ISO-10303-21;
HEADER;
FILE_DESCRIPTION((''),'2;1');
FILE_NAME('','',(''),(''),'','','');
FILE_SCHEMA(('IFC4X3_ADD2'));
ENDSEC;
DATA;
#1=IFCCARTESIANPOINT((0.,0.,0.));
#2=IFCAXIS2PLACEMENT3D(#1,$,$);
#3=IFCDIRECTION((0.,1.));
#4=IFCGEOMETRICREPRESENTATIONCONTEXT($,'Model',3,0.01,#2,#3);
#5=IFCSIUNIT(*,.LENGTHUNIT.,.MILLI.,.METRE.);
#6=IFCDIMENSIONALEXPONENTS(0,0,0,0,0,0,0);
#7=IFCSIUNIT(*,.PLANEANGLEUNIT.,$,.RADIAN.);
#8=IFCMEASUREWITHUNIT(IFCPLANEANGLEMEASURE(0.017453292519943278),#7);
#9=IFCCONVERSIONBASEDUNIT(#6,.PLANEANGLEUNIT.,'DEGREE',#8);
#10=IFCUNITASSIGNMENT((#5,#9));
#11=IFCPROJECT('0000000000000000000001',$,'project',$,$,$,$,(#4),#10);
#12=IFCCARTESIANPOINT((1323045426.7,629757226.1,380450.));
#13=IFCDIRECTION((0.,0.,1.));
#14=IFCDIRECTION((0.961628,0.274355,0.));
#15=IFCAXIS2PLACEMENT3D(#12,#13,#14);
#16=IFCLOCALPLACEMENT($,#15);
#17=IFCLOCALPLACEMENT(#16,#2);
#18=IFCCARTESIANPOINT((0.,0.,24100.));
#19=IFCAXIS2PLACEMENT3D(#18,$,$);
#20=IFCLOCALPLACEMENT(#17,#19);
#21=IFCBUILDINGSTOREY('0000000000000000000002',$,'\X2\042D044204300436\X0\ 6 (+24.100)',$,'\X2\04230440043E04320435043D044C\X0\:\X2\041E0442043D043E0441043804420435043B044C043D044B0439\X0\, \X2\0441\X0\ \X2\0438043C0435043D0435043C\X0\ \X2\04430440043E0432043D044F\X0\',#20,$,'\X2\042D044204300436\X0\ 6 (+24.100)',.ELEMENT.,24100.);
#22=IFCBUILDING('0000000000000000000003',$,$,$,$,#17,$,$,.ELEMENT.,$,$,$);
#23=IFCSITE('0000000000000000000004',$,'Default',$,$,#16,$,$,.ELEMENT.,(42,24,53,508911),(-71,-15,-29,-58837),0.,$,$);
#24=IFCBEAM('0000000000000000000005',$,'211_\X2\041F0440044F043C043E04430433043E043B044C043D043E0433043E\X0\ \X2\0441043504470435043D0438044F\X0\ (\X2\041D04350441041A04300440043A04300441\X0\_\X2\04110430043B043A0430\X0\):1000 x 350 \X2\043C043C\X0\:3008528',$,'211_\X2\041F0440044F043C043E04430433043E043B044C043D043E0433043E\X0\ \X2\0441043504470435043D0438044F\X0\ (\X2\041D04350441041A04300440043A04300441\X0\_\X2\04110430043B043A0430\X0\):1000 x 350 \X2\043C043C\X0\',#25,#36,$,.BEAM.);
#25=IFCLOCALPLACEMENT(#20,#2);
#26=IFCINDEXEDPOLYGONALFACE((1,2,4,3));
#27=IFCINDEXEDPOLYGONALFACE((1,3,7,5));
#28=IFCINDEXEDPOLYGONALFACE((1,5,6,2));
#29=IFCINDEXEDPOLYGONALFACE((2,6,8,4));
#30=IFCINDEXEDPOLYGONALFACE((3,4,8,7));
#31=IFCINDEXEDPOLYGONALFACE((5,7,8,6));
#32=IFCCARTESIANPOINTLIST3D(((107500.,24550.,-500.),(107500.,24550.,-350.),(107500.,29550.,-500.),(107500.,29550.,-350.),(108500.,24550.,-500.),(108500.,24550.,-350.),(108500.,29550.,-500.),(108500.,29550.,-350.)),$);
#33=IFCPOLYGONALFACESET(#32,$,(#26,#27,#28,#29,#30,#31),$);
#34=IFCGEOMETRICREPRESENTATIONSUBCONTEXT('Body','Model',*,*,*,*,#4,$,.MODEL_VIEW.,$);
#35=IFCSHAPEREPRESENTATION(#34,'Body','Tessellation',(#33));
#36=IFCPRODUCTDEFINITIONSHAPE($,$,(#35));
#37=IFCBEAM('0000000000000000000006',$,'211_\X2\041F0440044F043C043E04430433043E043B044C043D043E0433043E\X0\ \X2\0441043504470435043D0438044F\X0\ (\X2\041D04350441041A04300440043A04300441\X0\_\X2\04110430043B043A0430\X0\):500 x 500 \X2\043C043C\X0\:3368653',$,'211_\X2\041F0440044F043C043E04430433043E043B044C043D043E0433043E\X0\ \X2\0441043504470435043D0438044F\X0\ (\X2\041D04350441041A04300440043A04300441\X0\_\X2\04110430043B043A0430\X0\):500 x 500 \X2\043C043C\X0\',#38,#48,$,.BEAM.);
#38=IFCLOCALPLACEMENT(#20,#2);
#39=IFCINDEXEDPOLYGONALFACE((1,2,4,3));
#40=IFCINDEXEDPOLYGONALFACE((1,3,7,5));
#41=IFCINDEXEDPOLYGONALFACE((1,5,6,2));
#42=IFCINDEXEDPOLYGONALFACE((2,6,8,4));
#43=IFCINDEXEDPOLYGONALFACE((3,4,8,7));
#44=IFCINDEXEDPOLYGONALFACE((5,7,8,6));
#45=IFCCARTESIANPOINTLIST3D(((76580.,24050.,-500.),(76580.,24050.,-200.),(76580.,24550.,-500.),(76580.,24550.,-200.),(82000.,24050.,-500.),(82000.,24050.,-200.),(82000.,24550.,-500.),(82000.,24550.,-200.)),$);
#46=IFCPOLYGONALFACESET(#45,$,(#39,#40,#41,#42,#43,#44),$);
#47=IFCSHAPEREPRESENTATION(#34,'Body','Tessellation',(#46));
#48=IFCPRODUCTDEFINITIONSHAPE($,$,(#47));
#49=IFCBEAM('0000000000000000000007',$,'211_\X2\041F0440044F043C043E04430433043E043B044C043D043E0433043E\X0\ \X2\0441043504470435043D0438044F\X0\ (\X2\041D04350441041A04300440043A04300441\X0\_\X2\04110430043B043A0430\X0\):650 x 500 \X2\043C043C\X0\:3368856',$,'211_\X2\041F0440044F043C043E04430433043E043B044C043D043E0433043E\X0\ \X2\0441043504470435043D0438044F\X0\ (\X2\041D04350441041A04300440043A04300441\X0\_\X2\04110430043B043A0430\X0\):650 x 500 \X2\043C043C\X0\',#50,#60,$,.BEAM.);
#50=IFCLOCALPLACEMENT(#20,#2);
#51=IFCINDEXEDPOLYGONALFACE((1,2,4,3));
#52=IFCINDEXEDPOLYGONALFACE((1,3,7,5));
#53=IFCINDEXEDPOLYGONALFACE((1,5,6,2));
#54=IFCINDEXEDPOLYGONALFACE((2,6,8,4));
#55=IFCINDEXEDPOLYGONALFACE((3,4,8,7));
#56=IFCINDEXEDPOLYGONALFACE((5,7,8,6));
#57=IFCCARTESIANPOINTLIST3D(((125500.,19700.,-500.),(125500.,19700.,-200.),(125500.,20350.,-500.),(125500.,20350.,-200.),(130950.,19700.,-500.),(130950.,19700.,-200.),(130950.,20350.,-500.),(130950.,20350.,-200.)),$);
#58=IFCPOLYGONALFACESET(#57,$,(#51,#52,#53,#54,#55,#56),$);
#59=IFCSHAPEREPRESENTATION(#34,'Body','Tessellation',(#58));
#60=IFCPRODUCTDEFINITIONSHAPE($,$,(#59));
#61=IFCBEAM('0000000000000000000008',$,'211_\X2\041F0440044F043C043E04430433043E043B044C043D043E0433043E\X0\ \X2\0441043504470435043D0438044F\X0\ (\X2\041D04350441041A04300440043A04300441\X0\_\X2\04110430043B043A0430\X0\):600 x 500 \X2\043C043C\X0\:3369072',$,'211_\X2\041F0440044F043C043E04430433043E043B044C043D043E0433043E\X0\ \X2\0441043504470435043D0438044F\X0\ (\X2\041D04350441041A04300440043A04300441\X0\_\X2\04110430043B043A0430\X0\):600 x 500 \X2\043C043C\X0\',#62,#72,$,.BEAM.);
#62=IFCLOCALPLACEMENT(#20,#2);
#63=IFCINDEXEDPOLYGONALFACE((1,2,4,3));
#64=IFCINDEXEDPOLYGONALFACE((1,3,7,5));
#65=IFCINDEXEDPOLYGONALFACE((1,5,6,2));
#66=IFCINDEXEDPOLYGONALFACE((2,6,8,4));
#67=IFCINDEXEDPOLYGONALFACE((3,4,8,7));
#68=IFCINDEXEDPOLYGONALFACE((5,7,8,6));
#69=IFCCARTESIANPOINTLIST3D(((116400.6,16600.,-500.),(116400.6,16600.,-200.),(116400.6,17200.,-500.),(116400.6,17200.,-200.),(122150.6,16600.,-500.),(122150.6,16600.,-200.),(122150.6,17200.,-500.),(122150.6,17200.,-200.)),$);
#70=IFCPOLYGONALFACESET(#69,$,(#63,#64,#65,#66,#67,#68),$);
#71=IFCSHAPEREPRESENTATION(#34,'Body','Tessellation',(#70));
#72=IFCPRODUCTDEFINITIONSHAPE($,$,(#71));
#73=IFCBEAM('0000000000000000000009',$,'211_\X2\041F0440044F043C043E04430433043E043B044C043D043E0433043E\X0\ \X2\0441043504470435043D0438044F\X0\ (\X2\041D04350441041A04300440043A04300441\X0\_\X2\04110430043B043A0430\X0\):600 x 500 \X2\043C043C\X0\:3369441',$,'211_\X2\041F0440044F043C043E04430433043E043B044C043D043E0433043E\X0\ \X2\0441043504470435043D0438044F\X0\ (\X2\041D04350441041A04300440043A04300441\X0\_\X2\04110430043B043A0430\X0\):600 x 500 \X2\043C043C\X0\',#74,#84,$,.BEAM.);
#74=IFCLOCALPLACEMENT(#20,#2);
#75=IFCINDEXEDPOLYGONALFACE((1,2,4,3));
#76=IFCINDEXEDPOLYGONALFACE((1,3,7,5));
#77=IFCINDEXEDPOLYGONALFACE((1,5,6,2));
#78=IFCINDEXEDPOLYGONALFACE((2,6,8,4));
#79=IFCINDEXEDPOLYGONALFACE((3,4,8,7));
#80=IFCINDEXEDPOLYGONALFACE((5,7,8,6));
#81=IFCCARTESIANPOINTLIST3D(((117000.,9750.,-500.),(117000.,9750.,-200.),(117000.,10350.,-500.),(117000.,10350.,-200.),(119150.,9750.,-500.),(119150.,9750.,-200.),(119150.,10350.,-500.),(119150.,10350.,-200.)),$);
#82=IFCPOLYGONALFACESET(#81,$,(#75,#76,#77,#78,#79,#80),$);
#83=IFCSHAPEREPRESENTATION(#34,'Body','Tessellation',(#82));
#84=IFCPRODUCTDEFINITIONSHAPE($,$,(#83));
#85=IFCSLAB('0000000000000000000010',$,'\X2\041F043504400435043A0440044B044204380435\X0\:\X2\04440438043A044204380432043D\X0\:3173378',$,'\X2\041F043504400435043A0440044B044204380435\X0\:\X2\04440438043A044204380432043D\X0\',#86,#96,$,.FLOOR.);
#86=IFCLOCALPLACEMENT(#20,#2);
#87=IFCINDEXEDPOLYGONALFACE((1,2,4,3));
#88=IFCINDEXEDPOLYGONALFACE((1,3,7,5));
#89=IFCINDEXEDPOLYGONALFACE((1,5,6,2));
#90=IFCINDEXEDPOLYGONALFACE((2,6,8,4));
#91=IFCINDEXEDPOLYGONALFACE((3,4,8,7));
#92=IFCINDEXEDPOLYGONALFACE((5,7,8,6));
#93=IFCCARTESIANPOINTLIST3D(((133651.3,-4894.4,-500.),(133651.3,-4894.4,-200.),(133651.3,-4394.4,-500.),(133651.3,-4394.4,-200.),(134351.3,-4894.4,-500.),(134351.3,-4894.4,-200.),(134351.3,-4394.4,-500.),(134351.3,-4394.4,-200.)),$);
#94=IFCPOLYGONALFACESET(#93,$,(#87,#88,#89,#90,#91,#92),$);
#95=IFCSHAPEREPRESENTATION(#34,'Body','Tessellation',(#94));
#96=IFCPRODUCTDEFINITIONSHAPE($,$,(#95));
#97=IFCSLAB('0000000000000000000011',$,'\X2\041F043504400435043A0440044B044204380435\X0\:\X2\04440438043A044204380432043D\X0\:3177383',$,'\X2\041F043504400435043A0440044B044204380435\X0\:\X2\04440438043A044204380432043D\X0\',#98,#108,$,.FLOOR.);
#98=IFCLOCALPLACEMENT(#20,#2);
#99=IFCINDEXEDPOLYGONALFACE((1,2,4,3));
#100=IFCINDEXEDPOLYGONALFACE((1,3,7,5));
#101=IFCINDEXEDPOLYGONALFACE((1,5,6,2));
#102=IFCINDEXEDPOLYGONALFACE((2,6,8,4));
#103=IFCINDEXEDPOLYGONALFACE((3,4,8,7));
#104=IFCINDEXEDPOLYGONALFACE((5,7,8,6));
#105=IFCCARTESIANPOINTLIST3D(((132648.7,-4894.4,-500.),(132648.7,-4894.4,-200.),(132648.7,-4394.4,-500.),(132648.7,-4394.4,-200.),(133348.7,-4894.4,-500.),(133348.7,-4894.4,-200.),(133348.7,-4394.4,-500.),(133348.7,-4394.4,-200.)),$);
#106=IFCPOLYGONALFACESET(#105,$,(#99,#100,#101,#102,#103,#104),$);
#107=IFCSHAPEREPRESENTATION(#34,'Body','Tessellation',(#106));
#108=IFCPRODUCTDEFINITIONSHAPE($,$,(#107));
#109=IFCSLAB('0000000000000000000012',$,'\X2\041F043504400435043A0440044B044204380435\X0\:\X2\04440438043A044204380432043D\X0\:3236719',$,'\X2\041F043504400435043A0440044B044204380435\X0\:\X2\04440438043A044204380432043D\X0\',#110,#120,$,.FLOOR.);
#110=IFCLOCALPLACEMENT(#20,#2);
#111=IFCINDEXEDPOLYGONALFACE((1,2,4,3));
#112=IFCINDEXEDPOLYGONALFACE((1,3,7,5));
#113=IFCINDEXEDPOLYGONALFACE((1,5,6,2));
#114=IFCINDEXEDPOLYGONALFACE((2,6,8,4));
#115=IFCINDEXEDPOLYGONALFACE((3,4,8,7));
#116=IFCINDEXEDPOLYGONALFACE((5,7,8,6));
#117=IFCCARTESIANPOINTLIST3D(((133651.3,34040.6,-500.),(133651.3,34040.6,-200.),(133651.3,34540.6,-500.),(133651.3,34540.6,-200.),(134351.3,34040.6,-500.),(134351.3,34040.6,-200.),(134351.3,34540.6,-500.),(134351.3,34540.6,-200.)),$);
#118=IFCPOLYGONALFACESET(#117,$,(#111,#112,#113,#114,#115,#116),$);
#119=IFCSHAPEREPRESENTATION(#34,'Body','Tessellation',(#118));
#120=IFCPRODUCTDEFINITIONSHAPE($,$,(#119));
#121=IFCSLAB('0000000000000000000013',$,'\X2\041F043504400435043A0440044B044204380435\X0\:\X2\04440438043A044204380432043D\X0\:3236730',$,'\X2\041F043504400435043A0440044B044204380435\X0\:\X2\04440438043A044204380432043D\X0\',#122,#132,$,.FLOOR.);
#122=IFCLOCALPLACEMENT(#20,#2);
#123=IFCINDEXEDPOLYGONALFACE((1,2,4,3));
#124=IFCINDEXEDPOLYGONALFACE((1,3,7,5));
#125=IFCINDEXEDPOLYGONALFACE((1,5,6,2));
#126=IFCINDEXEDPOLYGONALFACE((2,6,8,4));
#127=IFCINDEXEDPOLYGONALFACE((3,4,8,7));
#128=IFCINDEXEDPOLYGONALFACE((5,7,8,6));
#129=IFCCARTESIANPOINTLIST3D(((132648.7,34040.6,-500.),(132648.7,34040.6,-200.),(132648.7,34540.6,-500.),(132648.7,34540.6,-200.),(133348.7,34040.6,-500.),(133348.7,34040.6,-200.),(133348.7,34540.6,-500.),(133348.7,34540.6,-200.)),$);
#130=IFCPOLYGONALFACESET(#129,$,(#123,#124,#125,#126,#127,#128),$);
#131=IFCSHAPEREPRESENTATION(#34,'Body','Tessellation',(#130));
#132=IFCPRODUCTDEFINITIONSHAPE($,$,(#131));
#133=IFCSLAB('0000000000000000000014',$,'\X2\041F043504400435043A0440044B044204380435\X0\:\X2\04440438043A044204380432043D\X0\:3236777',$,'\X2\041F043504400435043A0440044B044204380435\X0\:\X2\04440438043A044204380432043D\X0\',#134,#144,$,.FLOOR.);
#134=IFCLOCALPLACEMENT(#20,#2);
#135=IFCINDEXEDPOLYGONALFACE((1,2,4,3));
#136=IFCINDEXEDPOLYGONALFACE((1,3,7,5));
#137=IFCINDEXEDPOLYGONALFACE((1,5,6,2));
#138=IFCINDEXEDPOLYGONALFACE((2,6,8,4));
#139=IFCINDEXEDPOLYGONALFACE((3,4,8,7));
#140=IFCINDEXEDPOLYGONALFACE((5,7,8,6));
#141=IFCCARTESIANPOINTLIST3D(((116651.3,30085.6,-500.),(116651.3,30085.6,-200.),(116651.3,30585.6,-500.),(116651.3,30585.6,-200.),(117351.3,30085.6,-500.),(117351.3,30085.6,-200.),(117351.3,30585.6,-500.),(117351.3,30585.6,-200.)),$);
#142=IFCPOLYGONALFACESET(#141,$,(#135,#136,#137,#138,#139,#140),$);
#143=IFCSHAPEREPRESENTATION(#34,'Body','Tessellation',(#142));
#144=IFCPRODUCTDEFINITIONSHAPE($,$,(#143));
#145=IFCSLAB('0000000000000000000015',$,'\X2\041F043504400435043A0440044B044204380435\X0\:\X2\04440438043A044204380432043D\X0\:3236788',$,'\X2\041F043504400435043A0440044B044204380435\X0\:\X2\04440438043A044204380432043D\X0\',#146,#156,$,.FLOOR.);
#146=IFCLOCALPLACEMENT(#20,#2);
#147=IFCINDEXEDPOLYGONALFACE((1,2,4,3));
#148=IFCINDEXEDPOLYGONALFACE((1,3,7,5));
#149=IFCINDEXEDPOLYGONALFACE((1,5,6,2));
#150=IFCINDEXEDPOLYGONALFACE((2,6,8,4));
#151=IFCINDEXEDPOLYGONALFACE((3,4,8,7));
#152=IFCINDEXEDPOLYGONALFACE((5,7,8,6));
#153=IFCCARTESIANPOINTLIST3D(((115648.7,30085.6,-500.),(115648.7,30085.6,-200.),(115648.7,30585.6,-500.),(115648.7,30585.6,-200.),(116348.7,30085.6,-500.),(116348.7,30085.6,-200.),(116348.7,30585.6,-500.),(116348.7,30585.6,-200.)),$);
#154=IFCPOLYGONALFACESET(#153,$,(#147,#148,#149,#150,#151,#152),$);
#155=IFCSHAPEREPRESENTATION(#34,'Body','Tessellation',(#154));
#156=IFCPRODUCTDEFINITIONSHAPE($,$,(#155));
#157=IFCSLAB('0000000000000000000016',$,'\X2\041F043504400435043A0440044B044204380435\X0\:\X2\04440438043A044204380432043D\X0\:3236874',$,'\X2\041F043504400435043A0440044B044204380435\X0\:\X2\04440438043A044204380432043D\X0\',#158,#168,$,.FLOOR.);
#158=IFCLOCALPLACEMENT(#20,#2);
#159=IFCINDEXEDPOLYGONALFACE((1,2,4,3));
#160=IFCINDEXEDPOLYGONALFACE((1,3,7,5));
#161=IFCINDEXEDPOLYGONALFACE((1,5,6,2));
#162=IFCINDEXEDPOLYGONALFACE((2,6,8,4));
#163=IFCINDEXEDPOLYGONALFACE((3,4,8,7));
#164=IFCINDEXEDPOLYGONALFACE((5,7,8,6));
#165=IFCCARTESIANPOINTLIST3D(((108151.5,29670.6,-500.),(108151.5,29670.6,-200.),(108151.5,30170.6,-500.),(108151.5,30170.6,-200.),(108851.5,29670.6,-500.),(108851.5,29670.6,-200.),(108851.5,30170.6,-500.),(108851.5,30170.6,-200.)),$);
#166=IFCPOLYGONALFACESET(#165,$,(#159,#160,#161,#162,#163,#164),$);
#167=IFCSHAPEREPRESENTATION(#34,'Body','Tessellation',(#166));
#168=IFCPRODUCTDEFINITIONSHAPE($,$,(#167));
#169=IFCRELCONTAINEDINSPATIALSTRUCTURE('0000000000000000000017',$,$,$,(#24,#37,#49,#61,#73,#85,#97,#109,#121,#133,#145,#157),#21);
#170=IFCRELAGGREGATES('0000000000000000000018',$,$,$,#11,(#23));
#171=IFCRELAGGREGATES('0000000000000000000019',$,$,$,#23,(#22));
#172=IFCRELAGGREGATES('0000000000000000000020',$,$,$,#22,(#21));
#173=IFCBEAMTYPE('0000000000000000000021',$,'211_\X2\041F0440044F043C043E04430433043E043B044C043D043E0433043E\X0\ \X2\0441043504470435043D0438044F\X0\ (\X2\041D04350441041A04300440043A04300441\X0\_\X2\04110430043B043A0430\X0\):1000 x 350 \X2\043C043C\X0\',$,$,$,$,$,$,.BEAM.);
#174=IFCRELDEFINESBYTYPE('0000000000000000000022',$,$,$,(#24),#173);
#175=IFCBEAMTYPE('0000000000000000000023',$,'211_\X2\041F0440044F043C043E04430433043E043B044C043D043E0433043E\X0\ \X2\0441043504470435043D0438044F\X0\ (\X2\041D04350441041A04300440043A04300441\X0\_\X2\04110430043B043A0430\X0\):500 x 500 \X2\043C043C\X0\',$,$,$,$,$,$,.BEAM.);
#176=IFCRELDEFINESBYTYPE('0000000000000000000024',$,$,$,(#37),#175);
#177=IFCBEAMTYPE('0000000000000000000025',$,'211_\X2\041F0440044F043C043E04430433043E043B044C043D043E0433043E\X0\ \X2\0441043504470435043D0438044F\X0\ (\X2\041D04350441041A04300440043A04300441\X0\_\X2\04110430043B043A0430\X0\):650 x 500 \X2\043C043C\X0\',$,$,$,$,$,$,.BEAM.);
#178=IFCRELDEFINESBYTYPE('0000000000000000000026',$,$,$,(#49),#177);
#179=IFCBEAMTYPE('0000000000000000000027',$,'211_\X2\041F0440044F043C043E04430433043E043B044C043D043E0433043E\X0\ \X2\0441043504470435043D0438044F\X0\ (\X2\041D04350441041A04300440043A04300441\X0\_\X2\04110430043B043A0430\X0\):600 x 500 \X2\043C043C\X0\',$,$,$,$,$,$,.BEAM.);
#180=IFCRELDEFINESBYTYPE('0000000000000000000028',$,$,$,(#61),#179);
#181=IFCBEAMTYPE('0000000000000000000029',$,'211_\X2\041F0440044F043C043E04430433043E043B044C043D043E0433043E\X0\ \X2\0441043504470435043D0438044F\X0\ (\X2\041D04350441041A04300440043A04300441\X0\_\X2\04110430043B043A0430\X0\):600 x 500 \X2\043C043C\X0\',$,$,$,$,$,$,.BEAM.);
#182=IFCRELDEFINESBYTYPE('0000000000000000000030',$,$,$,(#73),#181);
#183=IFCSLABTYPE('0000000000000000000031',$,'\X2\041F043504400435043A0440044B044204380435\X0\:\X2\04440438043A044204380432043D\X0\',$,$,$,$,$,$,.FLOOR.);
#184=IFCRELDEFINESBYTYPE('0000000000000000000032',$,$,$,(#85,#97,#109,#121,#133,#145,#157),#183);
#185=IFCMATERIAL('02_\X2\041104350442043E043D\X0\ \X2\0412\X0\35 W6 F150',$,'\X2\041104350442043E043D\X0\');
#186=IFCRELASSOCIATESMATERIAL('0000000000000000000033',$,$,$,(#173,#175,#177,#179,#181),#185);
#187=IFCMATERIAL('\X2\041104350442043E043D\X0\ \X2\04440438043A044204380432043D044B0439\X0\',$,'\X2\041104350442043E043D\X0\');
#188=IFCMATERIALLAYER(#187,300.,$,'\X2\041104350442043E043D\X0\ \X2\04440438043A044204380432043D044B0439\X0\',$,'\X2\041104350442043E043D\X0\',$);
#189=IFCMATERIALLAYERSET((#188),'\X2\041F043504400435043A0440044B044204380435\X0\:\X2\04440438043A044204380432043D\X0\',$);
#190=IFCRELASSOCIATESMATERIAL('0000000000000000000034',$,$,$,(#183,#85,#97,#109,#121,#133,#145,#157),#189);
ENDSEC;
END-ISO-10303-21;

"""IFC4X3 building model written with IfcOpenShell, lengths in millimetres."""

from ifc_helpers import new_model, entity, si_unit, converted_unit, direction, frame, frame_2d, origin, origin_2d_with_axis, place, context, subcontext, project, spatial, rectangle, extrude, source, transform, mapped, material, layer, layer_set, layer_usage, material_profile, profile_set, type_object, type_shapes, element, save


model = new_model("IFC4X3")

# Units and contexts
model_context = context("Model", 3, precision=0.01, world=origin(), true_north=direction((0.0, 1.0)))
body_context = subcontext(model_context, "Body", "Model", "MODEL_VIEW")
ifc_project = project(units=[si_unit("LENGTHUNIT", "METRE", prefix="MILLI"), converted_unit("PLANEANGLEUNIT", "DEGREE", entity("IfcPlaneAngleMeasure", 0.017453292519943278), si_unit("PLANEANGLEUNIT", "RADIAN"), dimensions=[0, 0, 0, 0, 0, 0, 0])], contexts=[model_context])

# Site, building, storey
site_placement = place(None, frame((1323045426.7, 629757226.1, 380450.0), z_axis=(0.0, 0.0, 1.0), x_axis=(0.961628, 0.274355, 0.0)))
site = spatial("IfcSite", under=ifc_project, at=site_placement, Name="Default", CompositionType="ELEMENT", RefLatitude=(42, 24, 53, 508911), RefLongitude=(-71, -15, -29, -58837), RefElevation=0.0)
building_placement = place(site_placement, origin())
building = spatial("IfcBuilding", under=site, at=building_placement, CompositionType="ELEMENT")
storey_placement = place(building_placement, frame((0.0, 0.0, 24100.0)))
storey = spatial("IfcBuildingStorey", under=building, at=storey_placement, Name="Этаж 6 (+24.100)", ObjectType="Уровень:Относительный, с именем уровня", LongName="Этаж 6 (+24.100)", CompositionType="ELEMENT", Elevation=24100.0)

# Beams
ifc_material_1 = material(Name="02_Бетон В35 W6 F150", Category="Бетон")
ifc_material_profile_1 = material_profile(ifc_material_1, rectangle(XDim=150.0, YDim=1000.0, at=frame_2d((0.0, 0.0), x_axis=(0.0, 1.0))), Name="1000 x 350 мм")
ifc_profile_set_1 = profile_set([ifc_material_profile_1], Name="1000 x 350 мм")
beam_type_1 = type_object("IfcBeamType", Name="211_Прямоугольного сечения (НесКаркас_Балка):1000 x 350 мм", PredefinedType="BEAM", material=ifc_profile_set_1)
shared_shape_1 = source(origin(), body_context, "Body", "SweptSolid", [
    extrude(rectangle(XDim=150.0, YDim=1000.0, at=frame_2d((0.0, 0.0), x_axis=(0.0, 1.0))), frame((108000.0, 29550.0, 23675.0), z_axis=(0.0, -1.0, 0.0), x_axis=(-1.0, 0.0, 0.0)), (0.0, 0.0, 1.0), 5000.0),
])
type_shapes(beam_type_1, [shared_shape_1])
beam_1_placement = place(storey_placement, frame((0.0, 0.0, -24100.0)))
element("IfcBeam", 1, at=beam_1_placement, inside=storey, type_object=beam_type_1, Name="211_Прямоугольного сечения (НесКаркас_Балка):1000 x 350 мм:3008528", ObjectType="211_Прямоугольного сечения (НесКаркас_Балка):1000 x 350 мм", PredefinedType="BEAM", context=body_context, shape_type="MappedRepresentation", body=[
    mapped(shared_shape_1, transform((0.0, 0.0, 0.0), scale=1.0)),
])
ifc_material_profile_2 = material_profile(ifc_material_1, rectangle(XDim=300.0, YDim=500.0, at=frame_2d((0.0, 0.0), x_axis=(1.0, 0.0))), Name="500 x 500 мм")
ifc_profile_set_2 = profile_set([ifc_material_profile_2], Name="500 x 500 мм")
beam_type_2 = type_object("IfcBeamType", Name="211_Прямоугольного сечения (НесКаркас_Балка):500 x 500 мм", PredefinedType="BEAM", material=ifc_profile_set_2)
shared_shape_2 = source(origin(), body_context, "Body", "SweptSolid", [
    extrude(rectangle(XDim=300.0, YDim=500.0, at=frame_2d((0.0, 0.0), x_axis=(1.0, 0.0))), frame((82000.0, 24300.0, 23750.0), z_axis=(-1.0, 0.0, 0.0), x_axis=(0.0, 0.0, -1.0)), (0.0, 0.0, 1.0), 5420.0),
])
type_shapes(beam_type_2, [shared_shape_2])
beam_2_placement = place(storey_placement, frame((0.0, 0.0, -24100.0)))
element("IfcBeam", 2, at=beam_2_placement, inside=storey, type_object=beam_type_2, Name="211_Прямоугольного сечения (НесКаркас_Балка):500 x 500 мм:3368653", ObjectType="211_Прямоугольного сечения (НесКаркас_Балка):500 x 500 мм", PredefinedType="BEAM", context=body_context, shape_type="MappedRepresentation", body=[
    mapped(shared_shape_2, transform((0.0, 0.0, 0.0), scale=1.0)),
])
ifc_material_profile_3 = material_profile(ifc_material_1, rectangle(XDim=300.0, YDim=650.0, at=frame_2d((0.0, 0.0), x_axis=(1.0, 0.0))), Name="650 x 500 мм")
ifc_profile_set_3 = profile_set([ifc_material_profile_3], Name="650 x 500 мм")
beam_type_3 = type_object("IfcBeamType", Name="211_Прямоугольного сечения (НесКаркас_Балка):650 x 500 мм", PredefinedType="BEAM", material=ifc_profile_set_3)
shared_shape_3 = source(origin(), body_context, "Body", "SweptSolid", [
    extrude(rectangle(XDim=300.0, YDim=650.0, at=frame_2d((0.0, 0.0), x_axis=(1.0, 0.0))), frame((130950.0, 20025.0, 23750.0), z_axis=(-1.0, 0.0, 0.0), x_axis=(0.0, 0.0, -1.0)), (0.0, 0.0, 1.0), 5450.0),
])
type_shapes(beam_type_3, [shared_shape_3])
beam_3_placement = place(storey_placement, frame((0.0, 0.0, -24100.0)))
element("IfcBeam", 3, at=beam_3_placement, inside=storey, type_object=beam_type_3, Name="211_Прямоугольного сечения (НесКаркас_Балка):650 x 500 мм:3368856", ObjectType="211_Прямоугольного сечения (НесКаркас_Балка):650 x 500 мм", PredefinedType="BEAM", context=body_context, shape_type="MappedRepresentation", body=[
    mapped(shared_shape_3, transform((0.0, 0.0, 0.0), scale=1.0)),
])
ifc_material_profile_4 = material_profile(ifc_material_1, rectangle(XDim=300.0, YDim=600.0, at=origin_2d_with_axis()), Name="600 x 500 мм")
ifc_profile_set_4 = profile_set([ifc_material_profile_4], Name="600 x 500 мм")
beam_type_4 = type_object("IfcBeamType", Name="211_Прямоугольного сечения (НесКаркас_Балка):600 x 500 мм", PredefinedType="BEAM", material=ifc_profile_set_4)
shared_shape_4 = source(origin(), body_context, "Body", "SweptSolid", [
    extrude(rectangle(XDim=300.0, YDim=600.0, at=origin_2d_with_axis()), frame((122150.6, 16900.0, 23750.0), z_axis=(-1.0, 0.0, 0.0), x_axis=(0.0, 0.0, -1.0)), (0.0, 0.0, 1.0), 5750.0),
])
type_shapes(beam_type_4, [shared_shape_4])
beam_4_placement = place(storey_placement, frame((0.0, 0.0, -24100.0)))
element("IfcBeam", 4, at=beam_4_placement, inside=storey, type_object=beam_type_4, Name="211_Прямоугольного сечения (НесКаркас_Балка):600 x 500 мм:3369072", ObjectType="211_Прямоугольного сечения (НесКаркас_Балка):600 x 500 мм", PredefinedType="BEAM", context=body_context, shape_type="MappedRepresentation", body=[
    mapped(shared_shape_4, transform((0.0, 0.0, 0.0), scale=1.0)),
])
beam_type_5 = type_object("IfcBeamType", Name="211_Прямоугольного сечения (НесКаркас_Балка):600 x 500 мм", PredefinedType="BEAM", material=ifc_profile_set_4)
shared_shape_5 = source(origin(), body_context, "Body", "SweptSolid", [
    extrude(rectangle(XDim=300.0, YDim=600.0, at=frame_2d((0.0, 0.0), x_axis=(1.0, 0.0))), frame((119150.0, 10050.0, 23750.0), z_axis=(-1.0, 0.0, 0.0), x_axis=(0.0, 0.0, -1.0)), (0.0, 0.0, 1.0), 2150.0),
])
type_shapes(beam_type_5, [shared_shape_5])
beam_5_placement = place(storey_placement, frame((0.0, 0.0, -24100.0)))
element("IfcBeam", 5, at=beam_5_placement, inside=storey, type_object=beam_type_5, Name="211_Прямоугольного сечения (НесКаркас_Балка):600 x 500 мм:3369441", ObjectType="211_Прямоугольного сечения (НесКаркас_Балка):600 x 500 мм", PredefinedType="BEAM", context=body_context, shape_type="MappedRepresentation", body=[
    mapped(shared_shape_5, transform((0.0, 0.0, 0.0), scale=1.0)),
])

# Slabs
ifc_material_2 = material(Name="Бетон фиктивный", Category="Бетон")
ifc_layer_1 = layer(ifc_material_2, 300.0, Name="Бетон фиктивный", Category="Бетон")
ifc_layer_set_1 = layer_set([ifc_layer_1], Name="Перекрытие:фиктивн")
ifc_layer_usage_1 = layer_usage(ifc_layer_set_1, "AXIS3", "POSITIVE", 0.0)
slab_type_1 = type_object("IfcSlabType", Name="Перекрытие:фиктивн", PredefinedType="FLOOR", material=ifc_layer_set_1)
slab_1_placement = place(storey_placement, origin())
element("IfcSlab", 6, at=slab_1_placement, inside=storey, type_object=slab_type_1, material=ifc_layer_usage_1, Name="Перекрытие:фиктивн:3173378", ObjectType="Перекрытие:фиктивн", PredefinedType="FLOOR", context=body_context, shape_type="SweptSolid", body=[
    extrude(rectangle(XDim=500.0, YDim=700.0, at=frame_2d((0.0, 0.0), x_axis=(1.0, 0.0))), frame((134001.3, -4644.4, -200.0), z_axis=(0.0, 0.0, -1.0), x_axis=(0.0, 1.0, 0.0)), (0.0, 0.0, 1.0), 300.0),
])
ifc_layer_usage_2 = layer_usage(ifc_layer_set_1, "AXIS3", "POSITIVE", 0.0)
slab_2_placement = place(storey_placement, origin())
element("IfcSlab", 7, at=slab_2_placement, inside=storey, type_object=slab_type_1, material=ifc_layer_usage_2, Name="Перекрытие:фиктивн:3177383", ObjectType="Перекрытие:фиктивн", PredefinedType="FLOOR", context=body_context, shape_type="SweptSolid", body=[
    extrude(rectangle(XDim=500.0, YDim=700.0, at=frame_2d((0.0, 0.0), x_axis=(1.0, 0.0))), frame((132998.7, -4644.4, -200.0), z_axis=(0.0, 0.0, -1.0), x_axis=(0.0, 1.0, 0.0)), (0.0, 0.0, 1.0), 300.0),
])
ifc_layer_usage_3 = layer_usage(ifc_layer_set_1, "AXIS3", "POSITIVE", 0.0)
slab_3_placement = place(storey_placement, origin())
element("IfcSlab", 8, at=slab_3_placement, inside=storey, type_object=slab_type_1, material=ifc_layer_usage_3, Name="Перекрытие:фиктивн:3236719", ObjectType="Перекрытие:фиктивн", PredefinedType="FLOOR", context=body_context, shape_type="SweptSolid", body=[
    extrude(rectangle(XDim=500.0, YDim=700.0, at=frame_2d((0.0, 0.0), x_axis=(1.0, 0.0))), frame((134001.3, 34290.6, -200.0), z_axis=(0.0, 0.0, -1.0), x_axis=(0.0, 1.0, 0.0)), (0.0, 0.0, 1.0), 300.0),
])
ifc_layer_usage_4 = layer_usage(ifc_layer_set_1, "AXIS3", "POSITIVE", 0.0)
slab_4_placement = place(storey_placement, origin())
element("IfcSlab", 9, at=slab_4_placement, inside=storey, type_object=slab_type_1, material=ifc_layer_usage_4, Name="Перекрытие:фиктивн:3236730", ObjectType="Перекрытие:фиктивн", PredefinedType="FLOOR", context=body_context, shape_type="SweptSolid", body=[
    extrude(rectangle(XDim=500.0, YDim=700.0, at=frame_2d((0.0, 0.0), x_axis=(1.0, 0.0))), frame((132998.7, 34290.6, -200.0), z_axis=(0.0, 0.0, -1.0), x_axis=(0.0, 1.0, 0.0)), (0.0, 0.0, 1.0), 300.0),
])
ifc_layer_usage_5 = layer_usage(ifc_layer_set_1, "AXIS3", "POSITIVE", 0.0)
slab_5_placement = place(storey_placement, origin())
element("IfcSlab", 10, at=slab_5_placement, inside=storey, type_object=slab_type_1, material=ifc_layer_usage_5, Name="Перекрытие:фиктивн:3236777", ObjectType="Перекрытие:фиктивн", PredefinedType="FLOOR", context=body_context, shape_type="SweptSolid", body=[
    extrude(rectangle(XDim=500.0, YDim=700.0, at=frame_2d((0.0, 0.0), x_axis=(1.0, 0.0))), frame((117001.3, 30335.6, -200.0), z_axis=(0.0, 0.0, -1.0), x_axis=(0.0, 1.0, 0.0)), (0.0, 0.0, 1.0), 300.0),
])
ifc_layer_usage_6 = layer_usage(ifc_layer_set_1, "AXIS3", "POSITIVE", 0.0)
slab_6_placement = place(storey_placement, origin())
element("IfcSlab", 11, at=slab_6_placement, inside=storey, type_object=slab_type_1, material=ifc_layer_usage_6, Name="Перекрытие:фиктивн:3236788", ObjectType="Перекрытие:фиктивн", PredefinedType="FLOOR", context=body_context, shape_type="SweptSolid", body=[
    extrude(rectangle(XDim=500.0, YDim=700.0, at=frame_2d((0.0, 0.0), x_axis=(1.0, 0.0))), frame((115998.7, 30335.6, -200.0), z_axis=(0.0, 0.0, -1.0), x_axis=(0.0, 1.0, 0.0)), (0.0, 0.0, 1.0), 300.0),
])
ifc_layer_usage_7 = layer_usage(ifc_layer_set_1, "AXIS3", "POSITIVE", 0.0)
slab_7_placement = place(storey_placement, origin())
element("IfcSlab", 12, at=slab_7_placement, inside=storey, type_object=slab_type_1, material=ifc_layer_usage_7, Name="Перекрытие:фиктивн:3236874", ObjectType="Перекрытие:фиктивн", PredefinedType="FLOOR", context=body_context, shape_type="SweptSolid", body=[
    extrude(rectangle(XDim=500.0, YDim=700.0, at=frame_2d((0.0, 0.0), x_axis=(1.0, 0.0))), frame((108501.5, 29920.6, -200.0), z_axis=(0.0, 0.0, -1.0), x_axis=(0.0, 1.0, 0.0)), (0.0, 0.0, 1.0), 300.0),
])

save(model, "model.ifc")
